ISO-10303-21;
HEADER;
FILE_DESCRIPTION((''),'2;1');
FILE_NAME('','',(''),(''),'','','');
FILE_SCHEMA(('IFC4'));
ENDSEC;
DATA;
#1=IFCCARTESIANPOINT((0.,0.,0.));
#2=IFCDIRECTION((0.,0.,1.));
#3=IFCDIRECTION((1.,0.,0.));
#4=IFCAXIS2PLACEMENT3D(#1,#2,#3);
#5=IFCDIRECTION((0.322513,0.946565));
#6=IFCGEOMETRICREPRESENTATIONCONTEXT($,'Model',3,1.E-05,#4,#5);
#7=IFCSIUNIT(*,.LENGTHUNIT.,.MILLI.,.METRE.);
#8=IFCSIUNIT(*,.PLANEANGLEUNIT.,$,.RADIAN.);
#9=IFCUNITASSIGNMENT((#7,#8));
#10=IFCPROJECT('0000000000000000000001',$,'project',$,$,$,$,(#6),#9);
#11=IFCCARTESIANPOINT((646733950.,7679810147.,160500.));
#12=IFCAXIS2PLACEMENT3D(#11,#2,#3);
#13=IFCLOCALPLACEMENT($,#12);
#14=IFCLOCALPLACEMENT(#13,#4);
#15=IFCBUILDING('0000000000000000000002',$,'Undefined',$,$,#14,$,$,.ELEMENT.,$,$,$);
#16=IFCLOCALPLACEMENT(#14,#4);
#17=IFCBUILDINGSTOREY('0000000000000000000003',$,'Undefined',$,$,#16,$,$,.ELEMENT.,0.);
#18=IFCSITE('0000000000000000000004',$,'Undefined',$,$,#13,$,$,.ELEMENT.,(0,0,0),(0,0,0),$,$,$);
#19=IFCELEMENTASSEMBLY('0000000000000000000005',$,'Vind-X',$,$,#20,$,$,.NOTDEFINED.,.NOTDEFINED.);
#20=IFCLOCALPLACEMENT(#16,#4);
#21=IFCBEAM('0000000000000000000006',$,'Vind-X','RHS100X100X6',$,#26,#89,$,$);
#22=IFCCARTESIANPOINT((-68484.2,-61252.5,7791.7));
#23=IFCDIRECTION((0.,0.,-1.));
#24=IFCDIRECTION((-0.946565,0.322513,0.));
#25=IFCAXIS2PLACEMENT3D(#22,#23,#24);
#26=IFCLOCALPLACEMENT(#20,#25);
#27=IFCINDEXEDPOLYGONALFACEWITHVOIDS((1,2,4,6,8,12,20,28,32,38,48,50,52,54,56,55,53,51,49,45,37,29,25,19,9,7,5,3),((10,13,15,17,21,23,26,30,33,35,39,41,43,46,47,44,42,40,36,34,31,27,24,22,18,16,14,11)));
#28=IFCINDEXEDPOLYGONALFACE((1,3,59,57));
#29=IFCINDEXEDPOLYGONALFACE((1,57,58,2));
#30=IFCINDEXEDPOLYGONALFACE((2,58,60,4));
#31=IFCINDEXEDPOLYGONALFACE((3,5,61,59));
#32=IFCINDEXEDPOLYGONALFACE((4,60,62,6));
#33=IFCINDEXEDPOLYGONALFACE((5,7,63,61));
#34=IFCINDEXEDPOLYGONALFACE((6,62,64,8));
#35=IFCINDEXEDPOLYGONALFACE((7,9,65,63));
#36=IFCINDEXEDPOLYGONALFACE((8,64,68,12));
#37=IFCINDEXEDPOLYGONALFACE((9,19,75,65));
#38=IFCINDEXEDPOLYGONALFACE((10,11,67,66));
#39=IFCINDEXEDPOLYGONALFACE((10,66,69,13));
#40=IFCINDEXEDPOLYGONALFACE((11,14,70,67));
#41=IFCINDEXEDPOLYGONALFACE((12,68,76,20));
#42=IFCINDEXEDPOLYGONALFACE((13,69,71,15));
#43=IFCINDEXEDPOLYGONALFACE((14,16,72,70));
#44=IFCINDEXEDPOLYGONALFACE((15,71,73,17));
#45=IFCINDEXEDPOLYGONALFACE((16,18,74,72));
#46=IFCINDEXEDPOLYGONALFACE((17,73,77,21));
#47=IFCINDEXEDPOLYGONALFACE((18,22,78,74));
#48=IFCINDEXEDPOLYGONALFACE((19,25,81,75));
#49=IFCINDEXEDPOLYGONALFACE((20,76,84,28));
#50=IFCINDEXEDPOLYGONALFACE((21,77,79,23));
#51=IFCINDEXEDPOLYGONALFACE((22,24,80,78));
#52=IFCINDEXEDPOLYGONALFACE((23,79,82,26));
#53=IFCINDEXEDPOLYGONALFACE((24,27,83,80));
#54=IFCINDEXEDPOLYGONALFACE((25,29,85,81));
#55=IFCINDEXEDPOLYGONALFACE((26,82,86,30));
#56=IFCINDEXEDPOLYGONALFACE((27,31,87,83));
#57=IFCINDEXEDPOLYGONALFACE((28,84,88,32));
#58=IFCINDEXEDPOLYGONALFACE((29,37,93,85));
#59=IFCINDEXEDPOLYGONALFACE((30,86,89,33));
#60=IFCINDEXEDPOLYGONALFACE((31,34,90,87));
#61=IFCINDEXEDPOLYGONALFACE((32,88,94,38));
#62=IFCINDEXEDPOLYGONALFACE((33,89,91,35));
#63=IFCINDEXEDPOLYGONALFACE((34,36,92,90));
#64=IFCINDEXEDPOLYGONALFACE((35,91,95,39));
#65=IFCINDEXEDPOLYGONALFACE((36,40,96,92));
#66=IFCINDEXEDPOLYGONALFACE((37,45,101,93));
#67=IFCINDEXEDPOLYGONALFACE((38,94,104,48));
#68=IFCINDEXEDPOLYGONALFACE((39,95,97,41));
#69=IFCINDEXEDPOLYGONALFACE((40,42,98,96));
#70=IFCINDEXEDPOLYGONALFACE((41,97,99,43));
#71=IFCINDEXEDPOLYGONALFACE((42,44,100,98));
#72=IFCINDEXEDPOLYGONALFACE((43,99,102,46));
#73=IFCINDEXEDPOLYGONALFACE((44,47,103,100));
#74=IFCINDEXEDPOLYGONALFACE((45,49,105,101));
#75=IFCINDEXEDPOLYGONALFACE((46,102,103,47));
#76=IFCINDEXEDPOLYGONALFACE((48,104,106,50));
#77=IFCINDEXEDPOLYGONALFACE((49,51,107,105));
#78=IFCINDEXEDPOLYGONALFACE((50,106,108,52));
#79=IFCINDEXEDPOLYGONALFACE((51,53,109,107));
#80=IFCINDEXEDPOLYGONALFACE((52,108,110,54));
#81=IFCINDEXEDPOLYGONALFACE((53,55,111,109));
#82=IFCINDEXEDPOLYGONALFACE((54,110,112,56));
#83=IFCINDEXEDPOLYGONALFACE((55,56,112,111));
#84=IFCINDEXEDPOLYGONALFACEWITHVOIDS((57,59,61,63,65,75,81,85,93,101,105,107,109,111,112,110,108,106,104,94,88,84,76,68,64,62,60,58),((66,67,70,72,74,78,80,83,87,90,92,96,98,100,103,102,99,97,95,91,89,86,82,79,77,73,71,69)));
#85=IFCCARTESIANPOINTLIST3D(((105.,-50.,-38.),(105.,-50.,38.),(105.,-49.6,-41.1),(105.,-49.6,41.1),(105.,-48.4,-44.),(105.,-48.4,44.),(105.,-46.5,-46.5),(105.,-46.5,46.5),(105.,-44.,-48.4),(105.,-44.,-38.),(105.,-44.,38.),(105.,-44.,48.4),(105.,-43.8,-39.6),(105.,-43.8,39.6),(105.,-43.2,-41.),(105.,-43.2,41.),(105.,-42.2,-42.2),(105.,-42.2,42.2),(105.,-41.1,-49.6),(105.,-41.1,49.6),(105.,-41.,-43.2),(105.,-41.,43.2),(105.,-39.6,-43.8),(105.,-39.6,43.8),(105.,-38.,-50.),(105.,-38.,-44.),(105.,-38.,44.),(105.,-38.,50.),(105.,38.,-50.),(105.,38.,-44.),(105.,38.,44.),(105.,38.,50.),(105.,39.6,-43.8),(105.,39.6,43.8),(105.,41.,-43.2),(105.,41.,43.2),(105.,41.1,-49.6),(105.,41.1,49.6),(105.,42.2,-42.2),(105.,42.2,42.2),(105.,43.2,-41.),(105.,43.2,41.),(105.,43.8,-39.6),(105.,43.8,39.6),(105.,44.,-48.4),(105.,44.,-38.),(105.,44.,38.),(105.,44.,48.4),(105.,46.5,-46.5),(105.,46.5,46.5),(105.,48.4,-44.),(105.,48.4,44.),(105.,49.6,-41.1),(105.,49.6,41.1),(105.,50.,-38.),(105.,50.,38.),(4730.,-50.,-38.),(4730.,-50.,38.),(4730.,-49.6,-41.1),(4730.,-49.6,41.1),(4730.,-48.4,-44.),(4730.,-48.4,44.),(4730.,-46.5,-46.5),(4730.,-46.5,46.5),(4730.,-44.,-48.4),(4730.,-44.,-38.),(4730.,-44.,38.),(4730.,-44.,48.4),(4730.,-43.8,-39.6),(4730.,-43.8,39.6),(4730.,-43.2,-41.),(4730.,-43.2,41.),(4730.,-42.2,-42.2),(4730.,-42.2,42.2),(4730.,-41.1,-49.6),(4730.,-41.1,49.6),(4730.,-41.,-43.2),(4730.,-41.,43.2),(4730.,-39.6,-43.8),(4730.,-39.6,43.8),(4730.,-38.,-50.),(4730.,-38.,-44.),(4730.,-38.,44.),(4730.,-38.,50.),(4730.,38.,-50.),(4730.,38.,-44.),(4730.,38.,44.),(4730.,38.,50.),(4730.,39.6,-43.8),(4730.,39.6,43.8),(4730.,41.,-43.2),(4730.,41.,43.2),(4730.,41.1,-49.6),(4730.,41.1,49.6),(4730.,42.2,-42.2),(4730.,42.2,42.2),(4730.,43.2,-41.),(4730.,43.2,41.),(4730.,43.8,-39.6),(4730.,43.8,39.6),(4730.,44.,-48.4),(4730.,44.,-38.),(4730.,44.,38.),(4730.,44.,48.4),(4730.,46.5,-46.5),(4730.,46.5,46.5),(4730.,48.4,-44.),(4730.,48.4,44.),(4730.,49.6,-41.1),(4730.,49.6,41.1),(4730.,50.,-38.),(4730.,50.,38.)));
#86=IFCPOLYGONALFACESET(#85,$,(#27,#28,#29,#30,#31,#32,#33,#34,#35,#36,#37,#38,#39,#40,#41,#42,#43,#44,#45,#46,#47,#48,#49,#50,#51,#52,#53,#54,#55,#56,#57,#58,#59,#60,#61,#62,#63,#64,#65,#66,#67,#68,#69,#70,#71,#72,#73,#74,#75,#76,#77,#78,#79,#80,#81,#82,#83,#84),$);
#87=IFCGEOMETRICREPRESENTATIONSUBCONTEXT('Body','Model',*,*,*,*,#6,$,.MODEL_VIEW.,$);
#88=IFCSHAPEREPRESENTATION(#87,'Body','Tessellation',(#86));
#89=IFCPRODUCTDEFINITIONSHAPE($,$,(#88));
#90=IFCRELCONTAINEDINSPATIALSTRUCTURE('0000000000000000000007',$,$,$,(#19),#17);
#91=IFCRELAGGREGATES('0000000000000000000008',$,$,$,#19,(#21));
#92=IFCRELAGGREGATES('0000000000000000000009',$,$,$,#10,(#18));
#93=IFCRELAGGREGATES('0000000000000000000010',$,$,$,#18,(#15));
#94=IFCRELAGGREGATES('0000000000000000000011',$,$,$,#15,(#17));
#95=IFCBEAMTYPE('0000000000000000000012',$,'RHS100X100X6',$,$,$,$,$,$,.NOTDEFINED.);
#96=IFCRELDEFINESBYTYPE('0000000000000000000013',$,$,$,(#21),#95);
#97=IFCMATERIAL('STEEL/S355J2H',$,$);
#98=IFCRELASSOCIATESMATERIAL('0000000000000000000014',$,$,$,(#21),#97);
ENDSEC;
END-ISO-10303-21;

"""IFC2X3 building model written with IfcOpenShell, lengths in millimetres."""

from ifc_helpers import new_model, si_unit, direction, frame, origin_with_axes, origin_2d_with_axis, place, context, subcontext, project, spatial, hollow_rectangle, extrude, clip, halfspace, material, type_object, element, aggregate, save


model = new_model("IFC2X3")

# Units and contexts
model_context = context("Model", 3, precision=1e-05, world=origin_with_axes(), true_north=direction((0.322513, 0.946565)))
body_context = subcontext(model_context, "Body", "Model", "MODEL_VIEW")
ifc_project = project(units=[si_unit("LENGTHUNIT", "METRE", prefix="MILLI"), si_unit("PLANEANGLEUNIT", "RADIAN")], contexts=[model_context])

# Site, building, storey
site_placement = place(None, frame((646733950.0, 7679810147.0, 160500.0), z_axis=(0.0, 0.0, 1.0), x_axis=(1.0, 0.0, 0.0)))
site = spatial("IfcSite", under=ifc_project, at=site_placement, Name="Undefined", CompositionType="ELEMENT", RefLatitude=(0, 0, 0), RefLongitude=(0, 0, 0))
building_placement = place(site_placement, origin_with_axes())
building = spatial("IfcBuilding", under=site, at=building_placement, Name="Undefined", CompositionType="ELEMENT")
storey_placement = place(building_placement, origin_with_axes())
storey = spatial("IfcBuildingStorey", under=building, at=storey_placement, Name="Undefined", CompositionType="ELEMENT", Elevation=0.0)

# Shared definitions
ifc_material_1 = material(Name="STEEL/S355J2H")

# Element assembly, beam
assembly_1_placement = place(storey_placement, origin_with_axes())
assembly_1 = element("IfcElementAssembly", 1, at=assembly_1_placement, inside=storey, Name="Vind-X", AssemblyPlace="NOTDEFINED", PredefinedType="NOTDEFINED")
beam_type_1 = type_object("IfcBeamType", Name="RHS100X100X6", PredefinedType="NOTDEFINED")
beam_1_placement = place(assembly_1_placement, frame((-68484.2, -61252.5, 7791.7), z_axis=(0.0, 0.0, -1.0), x_axis=(-0.946565, 0.322513, 0.0)))
beam_1 = element("IfcBeam", 2, at=beam_1_placement, type_object=beam_type_1, material=ifc_material_1, Name="Vind-X", Description="RHS100X100X6", context=body_context, shape_type="Clipping", body=[
    clip(clip(extrude(hollow_rectangle(XDim=100.0, YDim=100.0, WallThickness=6.0, InnerFilletRadius=6.0, OuterFilletRadius=12.0, at=origin_2d_with_axis()), frame((4835.0, 0.0, 0.0), z_axis=(-1.0, 0.0, 0.0), x_axis=(0.0, -1.0, 0.0)), (0.0, 0.0, 1.0), 4835.0), halfspace(frame((4730.0, 0.0, 0.0), z_axis=(-1.0, 0.0, 0.0), x_axis=(0.0, 1.0, 0.0)), True)), halfspace(frame((105.0, 0.0, 0.0), z_axis=(1.0, 0.0, 0.0), x_axis=(0.0, -1.0, 0.0)), True)),
])

aggregate(assembly_1, [beam_1])

save(model, "model.ifc")
